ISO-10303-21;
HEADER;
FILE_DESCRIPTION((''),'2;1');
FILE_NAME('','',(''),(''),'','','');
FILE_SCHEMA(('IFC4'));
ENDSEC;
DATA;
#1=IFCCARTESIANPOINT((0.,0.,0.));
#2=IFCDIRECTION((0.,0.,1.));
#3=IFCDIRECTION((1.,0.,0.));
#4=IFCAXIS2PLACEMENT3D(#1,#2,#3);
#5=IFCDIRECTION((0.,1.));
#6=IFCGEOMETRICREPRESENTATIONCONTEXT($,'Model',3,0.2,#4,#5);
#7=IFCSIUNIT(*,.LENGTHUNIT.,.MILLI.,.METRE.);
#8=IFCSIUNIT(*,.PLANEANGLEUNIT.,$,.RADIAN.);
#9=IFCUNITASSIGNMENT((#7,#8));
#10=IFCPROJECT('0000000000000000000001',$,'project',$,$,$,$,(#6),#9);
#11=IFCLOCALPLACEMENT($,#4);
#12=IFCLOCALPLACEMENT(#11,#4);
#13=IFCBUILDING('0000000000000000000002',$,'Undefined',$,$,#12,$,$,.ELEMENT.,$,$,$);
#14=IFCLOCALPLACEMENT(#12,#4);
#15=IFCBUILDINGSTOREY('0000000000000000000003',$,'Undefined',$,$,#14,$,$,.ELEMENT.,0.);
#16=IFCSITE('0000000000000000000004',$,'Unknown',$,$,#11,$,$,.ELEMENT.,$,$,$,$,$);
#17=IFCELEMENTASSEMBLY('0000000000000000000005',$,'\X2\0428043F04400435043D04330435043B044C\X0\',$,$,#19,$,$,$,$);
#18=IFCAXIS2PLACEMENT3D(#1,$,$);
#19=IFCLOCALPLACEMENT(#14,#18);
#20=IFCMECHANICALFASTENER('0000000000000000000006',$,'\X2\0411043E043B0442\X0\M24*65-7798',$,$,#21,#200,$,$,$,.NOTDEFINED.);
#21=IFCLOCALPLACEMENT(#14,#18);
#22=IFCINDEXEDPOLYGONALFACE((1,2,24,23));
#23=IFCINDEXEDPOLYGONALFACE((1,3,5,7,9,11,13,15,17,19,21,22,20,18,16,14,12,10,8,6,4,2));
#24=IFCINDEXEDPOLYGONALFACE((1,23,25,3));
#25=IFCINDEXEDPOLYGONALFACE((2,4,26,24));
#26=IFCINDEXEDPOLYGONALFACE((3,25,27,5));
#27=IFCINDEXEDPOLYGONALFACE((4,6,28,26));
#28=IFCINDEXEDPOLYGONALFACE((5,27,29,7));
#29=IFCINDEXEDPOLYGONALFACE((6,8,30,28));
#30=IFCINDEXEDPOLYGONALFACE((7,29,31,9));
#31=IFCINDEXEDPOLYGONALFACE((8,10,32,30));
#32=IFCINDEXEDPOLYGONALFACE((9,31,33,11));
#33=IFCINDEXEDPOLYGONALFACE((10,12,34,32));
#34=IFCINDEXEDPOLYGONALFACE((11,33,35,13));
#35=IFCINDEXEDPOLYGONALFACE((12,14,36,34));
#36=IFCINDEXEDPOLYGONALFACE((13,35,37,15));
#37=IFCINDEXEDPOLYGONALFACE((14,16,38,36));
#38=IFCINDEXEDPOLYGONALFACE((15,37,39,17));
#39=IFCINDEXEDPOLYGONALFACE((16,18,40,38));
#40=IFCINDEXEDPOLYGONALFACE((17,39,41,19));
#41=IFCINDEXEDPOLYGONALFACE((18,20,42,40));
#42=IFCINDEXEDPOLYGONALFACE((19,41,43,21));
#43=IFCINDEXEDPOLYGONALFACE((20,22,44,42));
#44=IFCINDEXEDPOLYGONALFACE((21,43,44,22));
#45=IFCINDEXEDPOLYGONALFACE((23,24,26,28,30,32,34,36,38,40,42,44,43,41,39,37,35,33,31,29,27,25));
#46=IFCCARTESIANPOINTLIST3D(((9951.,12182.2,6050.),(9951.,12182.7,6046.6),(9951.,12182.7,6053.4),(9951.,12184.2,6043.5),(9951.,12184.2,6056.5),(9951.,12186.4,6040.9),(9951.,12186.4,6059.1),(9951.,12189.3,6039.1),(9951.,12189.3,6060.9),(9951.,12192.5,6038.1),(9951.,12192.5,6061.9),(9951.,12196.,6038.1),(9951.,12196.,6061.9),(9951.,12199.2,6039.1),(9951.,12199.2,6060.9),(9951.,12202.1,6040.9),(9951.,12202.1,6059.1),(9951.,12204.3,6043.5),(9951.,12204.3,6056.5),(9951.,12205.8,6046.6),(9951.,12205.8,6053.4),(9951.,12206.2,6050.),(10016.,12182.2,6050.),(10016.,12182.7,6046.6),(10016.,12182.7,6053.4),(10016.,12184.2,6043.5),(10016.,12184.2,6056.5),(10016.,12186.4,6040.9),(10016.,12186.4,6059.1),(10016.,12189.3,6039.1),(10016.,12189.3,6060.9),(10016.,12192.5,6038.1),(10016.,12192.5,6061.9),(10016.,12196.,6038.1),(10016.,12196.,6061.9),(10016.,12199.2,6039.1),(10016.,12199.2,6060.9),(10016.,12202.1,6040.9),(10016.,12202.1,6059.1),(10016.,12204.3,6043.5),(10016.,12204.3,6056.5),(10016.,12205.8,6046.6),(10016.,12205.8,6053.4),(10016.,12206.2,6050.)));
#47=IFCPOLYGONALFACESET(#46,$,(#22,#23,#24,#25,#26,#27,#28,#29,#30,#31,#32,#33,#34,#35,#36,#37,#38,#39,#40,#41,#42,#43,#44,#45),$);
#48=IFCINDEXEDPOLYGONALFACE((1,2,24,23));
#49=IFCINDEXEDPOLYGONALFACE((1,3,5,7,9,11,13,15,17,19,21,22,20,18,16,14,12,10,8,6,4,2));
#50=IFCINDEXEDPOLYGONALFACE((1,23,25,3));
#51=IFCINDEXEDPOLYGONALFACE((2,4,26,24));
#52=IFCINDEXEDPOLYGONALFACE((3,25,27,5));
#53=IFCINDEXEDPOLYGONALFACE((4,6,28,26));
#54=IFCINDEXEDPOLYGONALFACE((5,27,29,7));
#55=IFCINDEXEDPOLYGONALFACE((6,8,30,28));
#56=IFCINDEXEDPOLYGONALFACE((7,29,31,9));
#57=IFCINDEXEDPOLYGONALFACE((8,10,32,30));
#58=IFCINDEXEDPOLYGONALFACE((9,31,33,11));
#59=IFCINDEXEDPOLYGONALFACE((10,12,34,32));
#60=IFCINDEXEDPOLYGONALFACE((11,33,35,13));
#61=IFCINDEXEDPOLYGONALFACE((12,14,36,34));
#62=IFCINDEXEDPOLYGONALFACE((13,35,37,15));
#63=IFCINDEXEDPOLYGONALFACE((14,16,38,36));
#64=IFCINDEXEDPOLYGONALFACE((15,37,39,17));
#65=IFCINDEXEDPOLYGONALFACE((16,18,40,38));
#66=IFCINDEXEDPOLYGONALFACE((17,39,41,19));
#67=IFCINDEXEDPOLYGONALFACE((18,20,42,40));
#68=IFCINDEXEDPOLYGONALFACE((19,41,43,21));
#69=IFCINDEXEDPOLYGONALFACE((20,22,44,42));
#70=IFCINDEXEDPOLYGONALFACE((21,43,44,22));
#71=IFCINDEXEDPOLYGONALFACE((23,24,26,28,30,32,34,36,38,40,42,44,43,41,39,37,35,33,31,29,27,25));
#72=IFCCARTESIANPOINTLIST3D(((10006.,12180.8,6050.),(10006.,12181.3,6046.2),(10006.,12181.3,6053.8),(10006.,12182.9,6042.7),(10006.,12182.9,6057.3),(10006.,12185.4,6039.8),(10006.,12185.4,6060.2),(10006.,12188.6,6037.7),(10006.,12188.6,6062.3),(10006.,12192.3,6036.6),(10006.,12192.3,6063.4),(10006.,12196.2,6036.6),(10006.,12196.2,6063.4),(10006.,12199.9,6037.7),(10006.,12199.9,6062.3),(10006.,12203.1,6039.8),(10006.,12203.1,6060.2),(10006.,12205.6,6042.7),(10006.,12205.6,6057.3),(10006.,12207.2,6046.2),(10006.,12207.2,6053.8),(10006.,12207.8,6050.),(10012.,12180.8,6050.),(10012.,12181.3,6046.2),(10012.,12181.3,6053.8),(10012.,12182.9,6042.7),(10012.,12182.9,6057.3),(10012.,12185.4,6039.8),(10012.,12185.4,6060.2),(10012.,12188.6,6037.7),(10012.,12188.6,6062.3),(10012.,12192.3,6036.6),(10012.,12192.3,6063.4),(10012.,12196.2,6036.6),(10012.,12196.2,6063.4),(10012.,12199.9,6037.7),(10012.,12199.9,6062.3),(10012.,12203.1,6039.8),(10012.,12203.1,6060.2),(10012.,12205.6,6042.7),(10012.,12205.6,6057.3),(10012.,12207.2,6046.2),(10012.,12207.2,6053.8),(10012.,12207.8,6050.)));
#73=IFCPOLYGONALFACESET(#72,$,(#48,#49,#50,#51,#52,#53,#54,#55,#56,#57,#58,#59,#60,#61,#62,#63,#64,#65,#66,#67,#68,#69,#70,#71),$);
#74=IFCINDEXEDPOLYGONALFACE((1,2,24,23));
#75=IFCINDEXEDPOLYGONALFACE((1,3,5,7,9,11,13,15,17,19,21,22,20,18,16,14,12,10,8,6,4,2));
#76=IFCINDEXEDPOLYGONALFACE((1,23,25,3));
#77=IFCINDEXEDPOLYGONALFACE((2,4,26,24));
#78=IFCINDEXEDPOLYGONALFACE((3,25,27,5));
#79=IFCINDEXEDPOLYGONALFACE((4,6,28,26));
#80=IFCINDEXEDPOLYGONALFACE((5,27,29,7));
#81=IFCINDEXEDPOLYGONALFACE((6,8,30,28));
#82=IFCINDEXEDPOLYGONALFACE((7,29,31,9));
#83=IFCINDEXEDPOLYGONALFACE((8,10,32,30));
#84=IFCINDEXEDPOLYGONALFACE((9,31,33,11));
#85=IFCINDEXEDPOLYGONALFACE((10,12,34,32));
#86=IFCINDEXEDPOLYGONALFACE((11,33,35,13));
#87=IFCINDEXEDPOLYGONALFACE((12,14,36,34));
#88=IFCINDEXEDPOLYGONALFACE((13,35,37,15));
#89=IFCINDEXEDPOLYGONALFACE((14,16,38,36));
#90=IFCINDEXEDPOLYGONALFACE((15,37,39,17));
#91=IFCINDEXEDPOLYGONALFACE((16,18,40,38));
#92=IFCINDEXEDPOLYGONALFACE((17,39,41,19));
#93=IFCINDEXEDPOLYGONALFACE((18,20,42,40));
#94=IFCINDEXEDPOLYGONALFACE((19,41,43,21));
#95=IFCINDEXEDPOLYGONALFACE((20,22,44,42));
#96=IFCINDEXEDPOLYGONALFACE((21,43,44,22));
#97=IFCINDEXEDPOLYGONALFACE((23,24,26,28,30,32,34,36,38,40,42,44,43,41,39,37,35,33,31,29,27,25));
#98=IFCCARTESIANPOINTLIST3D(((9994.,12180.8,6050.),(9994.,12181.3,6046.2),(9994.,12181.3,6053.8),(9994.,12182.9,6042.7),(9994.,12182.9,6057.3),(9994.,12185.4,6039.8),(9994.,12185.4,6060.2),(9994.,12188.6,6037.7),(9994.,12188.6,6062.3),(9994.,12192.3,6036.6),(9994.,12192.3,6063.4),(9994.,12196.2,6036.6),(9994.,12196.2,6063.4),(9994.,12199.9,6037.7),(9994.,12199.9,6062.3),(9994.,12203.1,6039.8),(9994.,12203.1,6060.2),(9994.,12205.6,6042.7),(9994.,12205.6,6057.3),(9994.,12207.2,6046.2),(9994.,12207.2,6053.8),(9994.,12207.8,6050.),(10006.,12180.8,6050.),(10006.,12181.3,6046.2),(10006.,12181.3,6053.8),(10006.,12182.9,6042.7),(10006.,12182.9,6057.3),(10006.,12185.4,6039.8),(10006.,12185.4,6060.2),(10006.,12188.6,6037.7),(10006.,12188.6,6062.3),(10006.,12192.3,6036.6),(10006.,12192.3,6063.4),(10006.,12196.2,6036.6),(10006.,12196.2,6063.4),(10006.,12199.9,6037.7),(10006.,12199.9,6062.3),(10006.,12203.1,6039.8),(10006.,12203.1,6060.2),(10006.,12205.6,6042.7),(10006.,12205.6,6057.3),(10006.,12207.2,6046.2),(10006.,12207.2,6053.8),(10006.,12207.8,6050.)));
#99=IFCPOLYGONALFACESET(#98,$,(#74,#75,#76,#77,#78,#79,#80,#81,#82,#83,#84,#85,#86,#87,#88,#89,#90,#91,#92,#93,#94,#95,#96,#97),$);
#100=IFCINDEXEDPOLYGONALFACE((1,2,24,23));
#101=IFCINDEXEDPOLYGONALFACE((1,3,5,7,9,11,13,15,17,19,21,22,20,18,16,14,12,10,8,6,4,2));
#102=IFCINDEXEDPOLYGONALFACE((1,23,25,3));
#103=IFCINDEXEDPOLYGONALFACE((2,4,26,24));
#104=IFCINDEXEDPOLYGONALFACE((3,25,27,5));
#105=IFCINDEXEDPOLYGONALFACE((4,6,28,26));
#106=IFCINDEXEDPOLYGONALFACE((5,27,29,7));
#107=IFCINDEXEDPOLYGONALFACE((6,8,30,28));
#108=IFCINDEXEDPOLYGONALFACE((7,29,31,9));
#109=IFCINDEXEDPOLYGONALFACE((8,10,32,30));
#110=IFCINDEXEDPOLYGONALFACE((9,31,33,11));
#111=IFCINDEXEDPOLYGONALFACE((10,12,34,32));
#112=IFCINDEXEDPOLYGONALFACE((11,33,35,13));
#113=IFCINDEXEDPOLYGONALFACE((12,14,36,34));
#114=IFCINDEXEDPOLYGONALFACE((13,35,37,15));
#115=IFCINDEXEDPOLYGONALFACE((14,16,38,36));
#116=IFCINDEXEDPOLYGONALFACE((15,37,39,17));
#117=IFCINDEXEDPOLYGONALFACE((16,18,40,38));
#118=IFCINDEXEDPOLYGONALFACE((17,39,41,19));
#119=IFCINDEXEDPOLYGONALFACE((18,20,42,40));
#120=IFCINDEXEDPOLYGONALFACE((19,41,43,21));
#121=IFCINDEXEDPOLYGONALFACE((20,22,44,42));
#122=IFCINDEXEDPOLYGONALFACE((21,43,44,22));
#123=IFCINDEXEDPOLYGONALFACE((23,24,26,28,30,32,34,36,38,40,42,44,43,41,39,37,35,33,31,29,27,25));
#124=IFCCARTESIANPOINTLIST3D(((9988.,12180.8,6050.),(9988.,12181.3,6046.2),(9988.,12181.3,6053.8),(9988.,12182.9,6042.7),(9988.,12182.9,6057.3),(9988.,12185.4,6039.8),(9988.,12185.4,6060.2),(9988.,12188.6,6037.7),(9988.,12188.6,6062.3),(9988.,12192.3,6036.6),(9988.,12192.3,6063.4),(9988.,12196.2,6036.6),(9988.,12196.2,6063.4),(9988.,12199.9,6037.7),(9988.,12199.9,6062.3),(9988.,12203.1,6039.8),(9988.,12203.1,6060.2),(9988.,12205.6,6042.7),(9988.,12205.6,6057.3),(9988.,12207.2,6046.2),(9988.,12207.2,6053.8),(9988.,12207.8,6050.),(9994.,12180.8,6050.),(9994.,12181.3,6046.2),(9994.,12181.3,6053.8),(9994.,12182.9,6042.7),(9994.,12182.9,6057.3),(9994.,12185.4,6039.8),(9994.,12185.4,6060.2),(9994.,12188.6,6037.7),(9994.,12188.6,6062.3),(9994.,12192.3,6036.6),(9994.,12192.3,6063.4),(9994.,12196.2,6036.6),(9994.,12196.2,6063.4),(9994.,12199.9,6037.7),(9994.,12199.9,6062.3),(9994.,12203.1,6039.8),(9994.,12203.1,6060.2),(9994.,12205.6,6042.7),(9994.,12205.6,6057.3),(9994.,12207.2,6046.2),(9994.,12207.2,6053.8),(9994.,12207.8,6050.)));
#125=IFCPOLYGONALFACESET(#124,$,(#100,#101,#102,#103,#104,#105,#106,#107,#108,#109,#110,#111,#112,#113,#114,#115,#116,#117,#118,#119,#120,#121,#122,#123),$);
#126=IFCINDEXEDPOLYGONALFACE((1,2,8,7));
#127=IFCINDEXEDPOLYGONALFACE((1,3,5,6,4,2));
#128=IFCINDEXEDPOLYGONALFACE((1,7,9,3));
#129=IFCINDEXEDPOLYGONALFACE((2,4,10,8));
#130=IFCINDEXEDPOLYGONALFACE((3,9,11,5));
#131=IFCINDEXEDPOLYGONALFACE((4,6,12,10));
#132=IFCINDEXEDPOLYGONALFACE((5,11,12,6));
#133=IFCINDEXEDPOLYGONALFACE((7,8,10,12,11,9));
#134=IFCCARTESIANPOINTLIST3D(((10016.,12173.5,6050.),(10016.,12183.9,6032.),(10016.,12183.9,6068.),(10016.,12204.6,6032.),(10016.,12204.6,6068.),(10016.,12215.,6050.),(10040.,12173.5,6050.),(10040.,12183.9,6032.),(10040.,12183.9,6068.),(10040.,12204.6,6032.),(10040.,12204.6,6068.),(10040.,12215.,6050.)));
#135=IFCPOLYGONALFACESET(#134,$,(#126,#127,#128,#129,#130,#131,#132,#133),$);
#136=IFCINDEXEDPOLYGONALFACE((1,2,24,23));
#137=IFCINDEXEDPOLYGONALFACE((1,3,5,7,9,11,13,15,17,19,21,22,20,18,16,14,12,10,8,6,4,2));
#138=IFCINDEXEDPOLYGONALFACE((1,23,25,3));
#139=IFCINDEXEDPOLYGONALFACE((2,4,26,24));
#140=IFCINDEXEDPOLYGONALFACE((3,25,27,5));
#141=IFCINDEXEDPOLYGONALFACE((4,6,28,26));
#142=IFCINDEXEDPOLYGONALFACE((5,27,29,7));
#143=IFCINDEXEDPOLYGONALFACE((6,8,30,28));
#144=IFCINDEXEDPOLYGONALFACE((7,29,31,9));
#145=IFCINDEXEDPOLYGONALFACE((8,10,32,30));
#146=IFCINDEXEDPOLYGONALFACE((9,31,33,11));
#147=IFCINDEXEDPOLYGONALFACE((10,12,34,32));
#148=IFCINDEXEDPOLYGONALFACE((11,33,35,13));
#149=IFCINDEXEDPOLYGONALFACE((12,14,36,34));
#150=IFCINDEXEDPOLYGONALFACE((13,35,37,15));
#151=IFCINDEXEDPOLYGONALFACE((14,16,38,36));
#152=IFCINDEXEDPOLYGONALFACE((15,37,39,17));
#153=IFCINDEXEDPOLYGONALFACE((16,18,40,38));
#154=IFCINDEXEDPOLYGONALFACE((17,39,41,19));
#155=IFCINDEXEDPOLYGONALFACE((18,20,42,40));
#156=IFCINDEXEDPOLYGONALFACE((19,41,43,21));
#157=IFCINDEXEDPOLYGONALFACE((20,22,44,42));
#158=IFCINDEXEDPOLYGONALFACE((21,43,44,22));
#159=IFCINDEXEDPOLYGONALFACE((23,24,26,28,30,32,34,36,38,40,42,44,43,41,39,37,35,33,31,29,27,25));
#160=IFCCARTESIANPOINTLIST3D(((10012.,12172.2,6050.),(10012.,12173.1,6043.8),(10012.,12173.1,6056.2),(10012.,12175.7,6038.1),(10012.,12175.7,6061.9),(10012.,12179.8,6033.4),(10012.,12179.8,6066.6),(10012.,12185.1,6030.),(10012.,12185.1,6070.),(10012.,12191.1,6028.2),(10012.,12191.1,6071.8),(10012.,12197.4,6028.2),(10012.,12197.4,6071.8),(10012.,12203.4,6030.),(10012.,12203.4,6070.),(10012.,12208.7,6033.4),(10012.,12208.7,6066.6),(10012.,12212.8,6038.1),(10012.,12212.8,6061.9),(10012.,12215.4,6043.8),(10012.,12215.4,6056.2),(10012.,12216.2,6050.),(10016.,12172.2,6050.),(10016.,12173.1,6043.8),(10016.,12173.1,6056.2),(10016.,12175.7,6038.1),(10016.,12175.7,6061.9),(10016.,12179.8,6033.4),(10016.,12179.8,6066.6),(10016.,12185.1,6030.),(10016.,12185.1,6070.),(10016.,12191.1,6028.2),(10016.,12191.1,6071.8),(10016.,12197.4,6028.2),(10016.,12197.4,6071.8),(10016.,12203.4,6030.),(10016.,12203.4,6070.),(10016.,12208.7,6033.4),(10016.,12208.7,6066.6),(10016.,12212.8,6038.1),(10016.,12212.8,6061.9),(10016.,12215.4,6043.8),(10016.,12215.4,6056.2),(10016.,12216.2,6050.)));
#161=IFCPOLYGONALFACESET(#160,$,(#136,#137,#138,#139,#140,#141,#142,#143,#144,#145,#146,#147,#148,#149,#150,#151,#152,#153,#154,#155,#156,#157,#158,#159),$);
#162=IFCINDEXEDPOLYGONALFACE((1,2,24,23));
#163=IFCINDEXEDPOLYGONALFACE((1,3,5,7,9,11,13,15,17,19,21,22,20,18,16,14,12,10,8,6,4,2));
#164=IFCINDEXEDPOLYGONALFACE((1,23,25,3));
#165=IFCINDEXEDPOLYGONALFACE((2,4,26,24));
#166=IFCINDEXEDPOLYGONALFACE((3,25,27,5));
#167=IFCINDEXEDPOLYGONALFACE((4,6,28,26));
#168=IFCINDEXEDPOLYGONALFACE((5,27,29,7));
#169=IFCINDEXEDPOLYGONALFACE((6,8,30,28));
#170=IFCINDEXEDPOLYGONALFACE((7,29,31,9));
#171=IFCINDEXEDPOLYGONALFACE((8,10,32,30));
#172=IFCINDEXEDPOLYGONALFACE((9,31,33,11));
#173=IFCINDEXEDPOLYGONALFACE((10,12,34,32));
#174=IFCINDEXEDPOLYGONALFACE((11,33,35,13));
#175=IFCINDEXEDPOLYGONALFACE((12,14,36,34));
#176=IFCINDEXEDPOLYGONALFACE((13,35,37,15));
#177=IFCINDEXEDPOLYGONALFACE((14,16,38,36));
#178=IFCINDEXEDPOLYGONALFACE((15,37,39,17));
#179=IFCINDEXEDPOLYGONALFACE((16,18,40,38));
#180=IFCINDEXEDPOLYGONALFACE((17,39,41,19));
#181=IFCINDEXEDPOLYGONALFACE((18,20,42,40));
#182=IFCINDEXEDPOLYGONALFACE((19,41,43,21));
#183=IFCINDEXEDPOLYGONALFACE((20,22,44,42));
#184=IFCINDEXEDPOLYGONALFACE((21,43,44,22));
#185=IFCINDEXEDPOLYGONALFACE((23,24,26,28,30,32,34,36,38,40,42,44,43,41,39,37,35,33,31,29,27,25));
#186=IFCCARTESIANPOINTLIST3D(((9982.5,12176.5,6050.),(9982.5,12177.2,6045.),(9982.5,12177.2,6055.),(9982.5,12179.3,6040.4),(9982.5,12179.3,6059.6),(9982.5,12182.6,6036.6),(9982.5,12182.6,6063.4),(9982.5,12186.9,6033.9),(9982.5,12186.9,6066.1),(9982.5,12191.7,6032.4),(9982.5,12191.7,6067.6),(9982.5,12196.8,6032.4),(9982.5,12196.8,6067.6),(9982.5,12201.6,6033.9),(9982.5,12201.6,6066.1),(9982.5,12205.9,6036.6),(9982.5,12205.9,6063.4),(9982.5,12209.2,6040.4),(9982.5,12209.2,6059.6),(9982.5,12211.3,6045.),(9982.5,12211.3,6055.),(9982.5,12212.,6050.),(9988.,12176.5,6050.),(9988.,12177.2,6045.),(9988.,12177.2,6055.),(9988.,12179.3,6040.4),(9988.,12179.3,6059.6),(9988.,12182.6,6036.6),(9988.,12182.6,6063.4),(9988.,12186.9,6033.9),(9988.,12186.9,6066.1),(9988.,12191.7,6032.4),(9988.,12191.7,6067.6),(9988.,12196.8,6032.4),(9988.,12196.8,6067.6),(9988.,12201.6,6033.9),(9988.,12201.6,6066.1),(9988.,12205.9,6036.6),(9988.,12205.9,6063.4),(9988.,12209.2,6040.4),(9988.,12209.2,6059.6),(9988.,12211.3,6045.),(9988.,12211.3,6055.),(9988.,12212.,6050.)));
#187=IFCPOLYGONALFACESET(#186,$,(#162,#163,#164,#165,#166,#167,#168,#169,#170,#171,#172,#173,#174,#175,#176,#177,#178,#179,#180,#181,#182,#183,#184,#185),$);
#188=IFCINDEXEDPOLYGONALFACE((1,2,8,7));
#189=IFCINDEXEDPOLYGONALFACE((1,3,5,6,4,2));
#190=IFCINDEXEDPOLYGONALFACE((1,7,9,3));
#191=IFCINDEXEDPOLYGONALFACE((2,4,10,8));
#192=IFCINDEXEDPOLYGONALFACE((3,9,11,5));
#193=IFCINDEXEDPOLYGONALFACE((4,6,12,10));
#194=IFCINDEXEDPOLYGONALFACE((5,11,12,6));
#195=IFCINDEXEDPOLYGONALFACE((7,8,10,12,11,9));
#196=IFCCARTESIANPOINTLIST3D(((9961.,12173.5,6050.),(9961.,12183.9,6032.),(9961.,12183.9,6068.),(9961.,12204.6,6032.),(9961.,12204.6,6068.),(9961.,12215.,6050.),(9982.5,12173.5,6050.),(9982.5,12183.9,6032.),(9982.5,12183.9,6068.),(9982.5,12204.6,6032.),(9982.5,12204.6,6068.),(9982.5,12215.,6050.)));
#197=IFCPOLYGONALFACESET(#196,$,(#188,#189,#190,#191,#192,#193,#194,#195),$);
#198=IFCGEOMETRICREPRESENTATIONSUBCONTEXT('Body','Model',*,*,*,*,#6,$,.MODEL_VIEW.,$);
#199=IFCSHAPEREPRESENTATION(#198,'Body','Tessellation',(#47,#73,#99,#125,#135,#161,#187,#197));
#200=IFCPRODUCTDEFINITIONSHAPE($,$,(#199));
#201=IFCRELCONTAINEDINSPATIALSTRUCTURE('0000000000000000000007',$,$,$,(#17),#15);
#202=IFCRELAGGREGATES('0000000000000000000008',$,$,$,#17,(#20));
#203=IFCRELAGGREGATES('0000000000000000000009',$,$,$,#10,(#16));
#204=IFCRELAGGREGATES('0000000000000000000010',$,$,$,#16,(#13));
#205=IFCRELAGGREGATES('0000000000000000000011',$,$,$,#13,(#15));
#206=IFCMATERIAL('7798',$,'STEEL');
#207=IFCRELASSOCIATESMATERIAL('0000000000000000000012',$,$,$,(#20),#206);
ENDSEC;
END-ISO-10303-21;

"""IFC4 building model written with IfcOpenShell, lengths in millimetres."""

from ifc_helpers import new_model, si_unit, direction, frame, origin_with_axes, place, context, subcontext, project, spatial, line, arc, indexed_curve, outline, extrude, source, transform, mapped, material, element, aggregate, save


model = new_model("IFC4")

# Units and contexts
model_context = context("Model", 3, precision=0.2, world=origin_with_axes(), true_north=direction((0.0, 1.0)))
body_context = subcontext(model_context, "Body", "Model", "MODEL_VIEW")
ifc_project = project(units=[si_unit("LENGTHUNIT", "METRE", prefix="MILLI"), si_unit("PLANEANGLEUNIT", "RADIAN")], contexts=[model_context])

# Site, building, storey
site_placement = place(None, origin_with_axes())
site = spatial("IfcSite", under=ifc_project, at=site_placement, Name="Unknown", CompositionType="ELEMENT")
building_placement = place(site_placement, origin_with_axes())
building = spatial("IfcBuilding", under=site, at=building_placement, Name="Undefined", CompositionType="ELEMENT")
storey_placement = place(building_placement, origin_with_axes())
storey = spatial("IfcBuildingStorey", under=building, at=storey_placement, Name="Undefined", CompositionType="ELEMENT", Elevation=0.0)

# Shared definitions
ifc_material_1 = material(Name="7798", Category="STEEL")

# Element assembly, mechanical fastener
assembly_1_placement = place(storey_placement, frame((9949.0, 5673.0, 6045.0), z_axis=(0.0, 0.0, 1.0), x_axis=(0.0, 1.0, 0.0)))
assembly_1 = element("IfcElementAssembly", 1, at=assembly_1_placement, inside=storey, Name="Шпренгель")
shared_shape_1 = source(origin_with_axes(), body_context, "Body", "SweptSolid", [
    extrude(outline(indexed_curve([(12.0, 0.0), (0.0, 12.0), (-12.0, 0.0), (0.0, -12.0)], segments=[arc(1, 2, 3), arc(3, 4, 1)])), frame((0.0, 0.0, 16.0), z_axis=(0.0, 0.0, -1.0), x_axis=(0.0, 1.0, 0.0)), (0.0, 0.0, 1.0), 65.0),
    extrude(outline(indexed_curve([(13.5, 0.0), (0.0, 13.5), (-13.5, 0.0), (0.0, -13.5)], segments=[arc(1, 2, 3), arc(3, 4, 1)])), frame((0.0, 0.0, 12.0), z_axis=(0.0, 0.0, -1.0), x_axis=(0.0, 1.0, 0.0)), (0.0, 0.0, 1.0), 6.0),
    extrude(outline(indexed_curve([(13.5, 0.0), (0.0, 13.5), (-13.5, 0.0), (0.0, -13.5)], segments=[arc(1, 2, 3), arc(3, 4, 1)])), frame((0.0, 0.0, 6.0), z_axis=(0.0, 0.0, -1.0), x_axis=(0.0, 1.0, 0.0)), (0.0, 0.0, 1.0), 12.0),
    extrude(outline(indexed_curve([(13.5, 0.0), (0.0, 13.5), (-13.5, 0.0), (0.0, -13.5)], segments=[arc(1, 2, 3), arc(3, 4, 1)])), frame((0.0, 0.0, -6.0), z_axis=(0.0, 0.0, -1.0), x_axis=(0.0, 1.0, 0.0)), (0.0, 0.0, 1.0), 6.0),
    extrude(outline(indexed_curve([(20.8, 0.0), (10.4, 18.0), (-10.4, 18.0), (-20.8, 0.0), (-10.4, -18.0), (10.4, -18.0)], segments=[line(1, 2, 3, 4, 5, 6, 1)])), frame((0.0, 0.0, 40.0), z_axis=(0.0, 0.0, -1.0), x_axis=(0.0, 1.0, 0.0)), (0.0, 0.0, 1.0), 24.0),
    extrude(outline(indexed_curve([(22.0, 0.0), (0.0, 22.0), (-22.0, 0.0), (0.0, -22.0)], segments=[arc(1, 2, 3), arc(3, 4, 1)])), frame((0.0, 0.0, 16.0), z_axis=(0.0, 0.0, -1.0), x_axis=(0.0, 1.0, 0.0)), (0.0, 0.0, 1.0), 4.0),
    extrude(outline(indexed_curve([(17.8, 0.0), (0.0, 17.8), (-17.8, 0.0), (0.0, -17.8)], segments=[arc(1, 2, 3), arc(3, 4, 1)])), frame((0.0, 0.0, -12.0), z_axis=(0.0, 0.0, -1.0), x_axis=(0.0, 1.0, 0.0)), (0.0, 0.0, 1.0), 5.5),
    extrude(outline(indexed_curve([(20.8, 0.0), (10.4, 18.0), (-10.4, 18.0), (-20.8, 0.0), (-10.4, -18.0), (10.4, -18.0)], segments=[line(1, 2, 3, 4, 5, 6, 1)])), frame((0.0, 0.0, -17.5), z_axis=(0.0, 0.0, -1.0), x_axis=(0.0, 1.0, 0.0)), (0.0, 0.0, 1.0), 21.5),
])
mechanical_fastener_1_placement = place(assembly_1_placement, frame((6521.2, -51.0, 5.0), z_axis=(0.0, -1.0, 0.0), x_axis=(0.0, 0.0, 1.0)))
mechanical_fastener_1 = element("IfcMechanicalFastener", 2, at=mechanical_fastener_1_placement, material=ifc_material_1, Name="БолтM24*65-7798", PredefinedType="NOTDEFINED", context=body_context, shape_type="MappedRepresentation", body=[
    mapped(shared_shape_1, transform((0.0, 0.0, 0.0))),
])
aggregate(assembly_1, [mechanical_fastener_1])

save(model, "model.ifc")
